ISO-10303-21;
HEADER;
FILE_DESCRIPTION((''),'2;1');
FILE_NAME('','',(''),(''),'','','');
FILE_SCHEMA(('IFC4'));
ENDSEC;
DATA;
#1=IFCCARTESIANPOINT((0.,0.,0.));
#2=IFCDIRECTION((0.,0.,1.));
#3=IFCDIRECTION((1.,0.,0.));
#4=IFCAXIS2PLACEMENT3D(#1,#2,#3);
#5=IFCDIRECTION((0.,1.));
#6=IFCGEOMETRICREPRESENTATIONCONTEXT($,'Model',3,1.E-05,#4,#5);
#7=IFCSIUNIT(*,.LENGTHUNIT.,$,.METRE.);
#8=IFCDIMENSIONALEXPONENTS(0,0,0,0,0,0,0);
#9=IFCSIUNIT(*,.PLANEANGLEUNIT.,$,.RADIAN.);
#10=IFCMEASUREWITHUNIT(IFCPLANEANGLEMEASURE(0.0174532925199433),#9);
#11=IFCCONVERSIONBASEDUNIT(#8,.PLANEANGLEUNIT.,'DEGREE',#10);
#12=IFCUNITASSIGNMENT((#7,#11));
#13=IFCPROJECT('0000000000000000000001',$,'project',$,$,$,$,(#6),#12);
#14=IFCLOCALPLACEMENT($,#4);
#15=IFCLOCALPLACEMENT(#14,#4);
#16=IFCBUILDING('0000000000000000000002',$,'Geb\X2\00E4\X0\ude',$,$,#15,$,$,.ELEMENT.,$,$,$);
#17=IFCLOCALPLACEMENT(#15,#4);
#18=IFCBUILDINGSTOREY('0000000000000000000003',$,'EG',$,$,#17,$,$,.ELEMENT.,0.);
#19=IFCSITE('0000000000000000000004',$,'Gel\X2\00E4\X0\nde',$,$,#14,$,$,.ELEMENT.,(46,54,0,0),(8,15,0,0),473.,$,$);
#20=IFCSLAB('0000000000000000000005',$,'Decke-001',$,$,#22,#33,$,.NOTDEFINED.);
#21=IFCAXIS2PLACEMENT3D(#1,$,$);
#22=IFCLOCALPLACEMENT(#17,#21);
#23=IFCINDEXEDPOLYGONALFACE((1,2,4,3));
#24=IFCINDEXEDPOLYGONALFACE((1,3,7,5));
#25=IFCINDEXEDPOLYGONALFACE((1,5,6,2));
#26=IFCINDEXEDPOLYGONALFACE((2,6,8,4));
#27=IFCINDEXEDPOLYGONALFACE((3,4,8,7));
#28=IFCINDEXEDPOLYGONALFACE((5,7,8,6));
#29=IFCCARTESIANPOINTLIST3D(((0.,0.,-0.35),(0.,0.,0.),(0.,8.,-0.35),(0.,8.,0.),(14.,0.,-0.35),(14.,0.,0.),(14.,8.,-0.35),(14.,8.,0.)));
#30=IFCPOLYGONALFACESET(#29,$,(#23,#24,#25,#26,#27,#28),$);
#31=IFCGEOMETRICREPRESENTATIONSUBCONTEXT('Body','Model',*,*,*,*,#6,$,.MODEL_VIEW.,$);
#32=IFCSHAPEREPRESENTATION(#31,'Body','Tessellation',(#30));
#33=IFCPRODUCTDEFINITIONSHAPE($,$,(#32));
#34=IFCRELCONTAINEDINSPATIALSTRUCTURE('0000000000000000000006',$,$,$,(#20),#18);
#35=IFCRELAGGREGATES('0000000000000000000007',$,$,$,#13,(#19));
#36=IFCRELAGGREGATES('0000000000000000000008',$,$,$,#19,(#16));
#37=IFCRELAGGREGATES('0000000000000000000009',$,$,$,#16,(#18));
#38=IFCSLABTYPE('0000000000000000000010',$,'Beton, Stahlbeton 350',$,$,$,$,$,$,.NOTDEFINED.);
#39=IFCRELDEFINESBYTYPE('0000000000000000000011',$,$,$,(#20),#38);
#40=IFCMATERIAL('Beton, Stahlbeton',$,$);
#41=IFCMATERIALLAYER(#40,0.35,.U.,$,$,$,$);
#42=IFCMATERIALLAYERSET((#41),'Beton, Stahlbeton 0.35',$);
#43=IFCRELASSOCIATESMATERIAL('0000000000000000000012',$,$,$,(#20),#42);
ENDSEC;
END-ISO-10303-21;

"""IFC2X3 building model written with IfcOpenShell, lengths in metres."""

from ifc_helpers import new_model, entity, si_unit, converted_unit, direction, frame, origin_with_axes, place, context, subcontext, project, spatial, polyline, outline, extrude, material, layer, layer_set, layer_usage, type_object, element, save


model = new_model("IFC2X3")

# Units and contexts
model_context = context("Model", 3, precision=1e-05, world=origin_with_axes(), true_north=direction((0.0, 1.0)))
body_context = subcontext(model_context, "Body", "Model", "MODEL_VIEW")
ifc_project = project(units=[si_unit("LENGTHUNIT", "METRE"), converted_unit("PLANEANGLEUNIT", "DEGREE", entity("IfcPlaneAngleMeasure", 0.0174532925199433), si_unit("PLANEANGLEUNIT", "RADIAN"), dimensions=[0, 0, 0, 0, 0, 0, 0])], contexts=[model_context])

# Site, building, storey
site_placement = place(None, origin_with_axes())
site = spatial("IfcSite", under=ifc_project, at=site_placement, Name="Gelände", CompositionType="ELEMENT", RefLatitude=(46, 54, 0, 0), RefLongitude=(8, 15, 0, 0), RefElevation=473.0)
building_placement = place(site_placement, origin_with_axes())
building = spatial("IfcBuilding", under=site, at=building_placement, Name="Gebäude", CompositionType="ELEMENT")
storey_placement = place(building_placement, origin_with_axes())
storey = spatial("IfcBuildingStorey", under=building, at=storey_placement, Name="EG", CompositionType="ELEMENT", Elevation=0.0)

# Slab
ifc_material = material(Name="Beton, Stahlbeton")
ifc_layer = layer(ifc_material, 0.35, ventilated="UNKNOWN")
ifc_layer_set = layer_set([ifc_layer], Name="Beton, Stahlbeton 0.35")
ifc_layer_usage = layer_usage(ifc_layer_set, "AXIS3", "NEGATIVE", 0.35)
slab_type = type_object("IfcSlabType", Name="Beton, Stahlbeton 350", PredefinedType="NOTDEFINED")
slab_placement = place(storey_placement, origin_with_axes())
element("IfcSlab", 1, at=slab_placement, inside=storey, type_object=slab_type, material=ifc_layer_usage, Name="Decke-001", PredefinedType="NOTDEFINED", context=body_context, shape_type="SweptSolid", body=[
    extrude(outline(polyline([(0.0, 0.0), (14.0, 0.0), (14.0, 8.0), (0.0, 8.0), (0.0, 0.0)])), frame((0.0, 0.0, -0.35), z_axis=(0.0, 0.0, 1.0), x_axis=(1.0, 0.0, 0.0)), (0.0, 0.0, 1.0), 0.35),
])

save(model, "model.ifc")
